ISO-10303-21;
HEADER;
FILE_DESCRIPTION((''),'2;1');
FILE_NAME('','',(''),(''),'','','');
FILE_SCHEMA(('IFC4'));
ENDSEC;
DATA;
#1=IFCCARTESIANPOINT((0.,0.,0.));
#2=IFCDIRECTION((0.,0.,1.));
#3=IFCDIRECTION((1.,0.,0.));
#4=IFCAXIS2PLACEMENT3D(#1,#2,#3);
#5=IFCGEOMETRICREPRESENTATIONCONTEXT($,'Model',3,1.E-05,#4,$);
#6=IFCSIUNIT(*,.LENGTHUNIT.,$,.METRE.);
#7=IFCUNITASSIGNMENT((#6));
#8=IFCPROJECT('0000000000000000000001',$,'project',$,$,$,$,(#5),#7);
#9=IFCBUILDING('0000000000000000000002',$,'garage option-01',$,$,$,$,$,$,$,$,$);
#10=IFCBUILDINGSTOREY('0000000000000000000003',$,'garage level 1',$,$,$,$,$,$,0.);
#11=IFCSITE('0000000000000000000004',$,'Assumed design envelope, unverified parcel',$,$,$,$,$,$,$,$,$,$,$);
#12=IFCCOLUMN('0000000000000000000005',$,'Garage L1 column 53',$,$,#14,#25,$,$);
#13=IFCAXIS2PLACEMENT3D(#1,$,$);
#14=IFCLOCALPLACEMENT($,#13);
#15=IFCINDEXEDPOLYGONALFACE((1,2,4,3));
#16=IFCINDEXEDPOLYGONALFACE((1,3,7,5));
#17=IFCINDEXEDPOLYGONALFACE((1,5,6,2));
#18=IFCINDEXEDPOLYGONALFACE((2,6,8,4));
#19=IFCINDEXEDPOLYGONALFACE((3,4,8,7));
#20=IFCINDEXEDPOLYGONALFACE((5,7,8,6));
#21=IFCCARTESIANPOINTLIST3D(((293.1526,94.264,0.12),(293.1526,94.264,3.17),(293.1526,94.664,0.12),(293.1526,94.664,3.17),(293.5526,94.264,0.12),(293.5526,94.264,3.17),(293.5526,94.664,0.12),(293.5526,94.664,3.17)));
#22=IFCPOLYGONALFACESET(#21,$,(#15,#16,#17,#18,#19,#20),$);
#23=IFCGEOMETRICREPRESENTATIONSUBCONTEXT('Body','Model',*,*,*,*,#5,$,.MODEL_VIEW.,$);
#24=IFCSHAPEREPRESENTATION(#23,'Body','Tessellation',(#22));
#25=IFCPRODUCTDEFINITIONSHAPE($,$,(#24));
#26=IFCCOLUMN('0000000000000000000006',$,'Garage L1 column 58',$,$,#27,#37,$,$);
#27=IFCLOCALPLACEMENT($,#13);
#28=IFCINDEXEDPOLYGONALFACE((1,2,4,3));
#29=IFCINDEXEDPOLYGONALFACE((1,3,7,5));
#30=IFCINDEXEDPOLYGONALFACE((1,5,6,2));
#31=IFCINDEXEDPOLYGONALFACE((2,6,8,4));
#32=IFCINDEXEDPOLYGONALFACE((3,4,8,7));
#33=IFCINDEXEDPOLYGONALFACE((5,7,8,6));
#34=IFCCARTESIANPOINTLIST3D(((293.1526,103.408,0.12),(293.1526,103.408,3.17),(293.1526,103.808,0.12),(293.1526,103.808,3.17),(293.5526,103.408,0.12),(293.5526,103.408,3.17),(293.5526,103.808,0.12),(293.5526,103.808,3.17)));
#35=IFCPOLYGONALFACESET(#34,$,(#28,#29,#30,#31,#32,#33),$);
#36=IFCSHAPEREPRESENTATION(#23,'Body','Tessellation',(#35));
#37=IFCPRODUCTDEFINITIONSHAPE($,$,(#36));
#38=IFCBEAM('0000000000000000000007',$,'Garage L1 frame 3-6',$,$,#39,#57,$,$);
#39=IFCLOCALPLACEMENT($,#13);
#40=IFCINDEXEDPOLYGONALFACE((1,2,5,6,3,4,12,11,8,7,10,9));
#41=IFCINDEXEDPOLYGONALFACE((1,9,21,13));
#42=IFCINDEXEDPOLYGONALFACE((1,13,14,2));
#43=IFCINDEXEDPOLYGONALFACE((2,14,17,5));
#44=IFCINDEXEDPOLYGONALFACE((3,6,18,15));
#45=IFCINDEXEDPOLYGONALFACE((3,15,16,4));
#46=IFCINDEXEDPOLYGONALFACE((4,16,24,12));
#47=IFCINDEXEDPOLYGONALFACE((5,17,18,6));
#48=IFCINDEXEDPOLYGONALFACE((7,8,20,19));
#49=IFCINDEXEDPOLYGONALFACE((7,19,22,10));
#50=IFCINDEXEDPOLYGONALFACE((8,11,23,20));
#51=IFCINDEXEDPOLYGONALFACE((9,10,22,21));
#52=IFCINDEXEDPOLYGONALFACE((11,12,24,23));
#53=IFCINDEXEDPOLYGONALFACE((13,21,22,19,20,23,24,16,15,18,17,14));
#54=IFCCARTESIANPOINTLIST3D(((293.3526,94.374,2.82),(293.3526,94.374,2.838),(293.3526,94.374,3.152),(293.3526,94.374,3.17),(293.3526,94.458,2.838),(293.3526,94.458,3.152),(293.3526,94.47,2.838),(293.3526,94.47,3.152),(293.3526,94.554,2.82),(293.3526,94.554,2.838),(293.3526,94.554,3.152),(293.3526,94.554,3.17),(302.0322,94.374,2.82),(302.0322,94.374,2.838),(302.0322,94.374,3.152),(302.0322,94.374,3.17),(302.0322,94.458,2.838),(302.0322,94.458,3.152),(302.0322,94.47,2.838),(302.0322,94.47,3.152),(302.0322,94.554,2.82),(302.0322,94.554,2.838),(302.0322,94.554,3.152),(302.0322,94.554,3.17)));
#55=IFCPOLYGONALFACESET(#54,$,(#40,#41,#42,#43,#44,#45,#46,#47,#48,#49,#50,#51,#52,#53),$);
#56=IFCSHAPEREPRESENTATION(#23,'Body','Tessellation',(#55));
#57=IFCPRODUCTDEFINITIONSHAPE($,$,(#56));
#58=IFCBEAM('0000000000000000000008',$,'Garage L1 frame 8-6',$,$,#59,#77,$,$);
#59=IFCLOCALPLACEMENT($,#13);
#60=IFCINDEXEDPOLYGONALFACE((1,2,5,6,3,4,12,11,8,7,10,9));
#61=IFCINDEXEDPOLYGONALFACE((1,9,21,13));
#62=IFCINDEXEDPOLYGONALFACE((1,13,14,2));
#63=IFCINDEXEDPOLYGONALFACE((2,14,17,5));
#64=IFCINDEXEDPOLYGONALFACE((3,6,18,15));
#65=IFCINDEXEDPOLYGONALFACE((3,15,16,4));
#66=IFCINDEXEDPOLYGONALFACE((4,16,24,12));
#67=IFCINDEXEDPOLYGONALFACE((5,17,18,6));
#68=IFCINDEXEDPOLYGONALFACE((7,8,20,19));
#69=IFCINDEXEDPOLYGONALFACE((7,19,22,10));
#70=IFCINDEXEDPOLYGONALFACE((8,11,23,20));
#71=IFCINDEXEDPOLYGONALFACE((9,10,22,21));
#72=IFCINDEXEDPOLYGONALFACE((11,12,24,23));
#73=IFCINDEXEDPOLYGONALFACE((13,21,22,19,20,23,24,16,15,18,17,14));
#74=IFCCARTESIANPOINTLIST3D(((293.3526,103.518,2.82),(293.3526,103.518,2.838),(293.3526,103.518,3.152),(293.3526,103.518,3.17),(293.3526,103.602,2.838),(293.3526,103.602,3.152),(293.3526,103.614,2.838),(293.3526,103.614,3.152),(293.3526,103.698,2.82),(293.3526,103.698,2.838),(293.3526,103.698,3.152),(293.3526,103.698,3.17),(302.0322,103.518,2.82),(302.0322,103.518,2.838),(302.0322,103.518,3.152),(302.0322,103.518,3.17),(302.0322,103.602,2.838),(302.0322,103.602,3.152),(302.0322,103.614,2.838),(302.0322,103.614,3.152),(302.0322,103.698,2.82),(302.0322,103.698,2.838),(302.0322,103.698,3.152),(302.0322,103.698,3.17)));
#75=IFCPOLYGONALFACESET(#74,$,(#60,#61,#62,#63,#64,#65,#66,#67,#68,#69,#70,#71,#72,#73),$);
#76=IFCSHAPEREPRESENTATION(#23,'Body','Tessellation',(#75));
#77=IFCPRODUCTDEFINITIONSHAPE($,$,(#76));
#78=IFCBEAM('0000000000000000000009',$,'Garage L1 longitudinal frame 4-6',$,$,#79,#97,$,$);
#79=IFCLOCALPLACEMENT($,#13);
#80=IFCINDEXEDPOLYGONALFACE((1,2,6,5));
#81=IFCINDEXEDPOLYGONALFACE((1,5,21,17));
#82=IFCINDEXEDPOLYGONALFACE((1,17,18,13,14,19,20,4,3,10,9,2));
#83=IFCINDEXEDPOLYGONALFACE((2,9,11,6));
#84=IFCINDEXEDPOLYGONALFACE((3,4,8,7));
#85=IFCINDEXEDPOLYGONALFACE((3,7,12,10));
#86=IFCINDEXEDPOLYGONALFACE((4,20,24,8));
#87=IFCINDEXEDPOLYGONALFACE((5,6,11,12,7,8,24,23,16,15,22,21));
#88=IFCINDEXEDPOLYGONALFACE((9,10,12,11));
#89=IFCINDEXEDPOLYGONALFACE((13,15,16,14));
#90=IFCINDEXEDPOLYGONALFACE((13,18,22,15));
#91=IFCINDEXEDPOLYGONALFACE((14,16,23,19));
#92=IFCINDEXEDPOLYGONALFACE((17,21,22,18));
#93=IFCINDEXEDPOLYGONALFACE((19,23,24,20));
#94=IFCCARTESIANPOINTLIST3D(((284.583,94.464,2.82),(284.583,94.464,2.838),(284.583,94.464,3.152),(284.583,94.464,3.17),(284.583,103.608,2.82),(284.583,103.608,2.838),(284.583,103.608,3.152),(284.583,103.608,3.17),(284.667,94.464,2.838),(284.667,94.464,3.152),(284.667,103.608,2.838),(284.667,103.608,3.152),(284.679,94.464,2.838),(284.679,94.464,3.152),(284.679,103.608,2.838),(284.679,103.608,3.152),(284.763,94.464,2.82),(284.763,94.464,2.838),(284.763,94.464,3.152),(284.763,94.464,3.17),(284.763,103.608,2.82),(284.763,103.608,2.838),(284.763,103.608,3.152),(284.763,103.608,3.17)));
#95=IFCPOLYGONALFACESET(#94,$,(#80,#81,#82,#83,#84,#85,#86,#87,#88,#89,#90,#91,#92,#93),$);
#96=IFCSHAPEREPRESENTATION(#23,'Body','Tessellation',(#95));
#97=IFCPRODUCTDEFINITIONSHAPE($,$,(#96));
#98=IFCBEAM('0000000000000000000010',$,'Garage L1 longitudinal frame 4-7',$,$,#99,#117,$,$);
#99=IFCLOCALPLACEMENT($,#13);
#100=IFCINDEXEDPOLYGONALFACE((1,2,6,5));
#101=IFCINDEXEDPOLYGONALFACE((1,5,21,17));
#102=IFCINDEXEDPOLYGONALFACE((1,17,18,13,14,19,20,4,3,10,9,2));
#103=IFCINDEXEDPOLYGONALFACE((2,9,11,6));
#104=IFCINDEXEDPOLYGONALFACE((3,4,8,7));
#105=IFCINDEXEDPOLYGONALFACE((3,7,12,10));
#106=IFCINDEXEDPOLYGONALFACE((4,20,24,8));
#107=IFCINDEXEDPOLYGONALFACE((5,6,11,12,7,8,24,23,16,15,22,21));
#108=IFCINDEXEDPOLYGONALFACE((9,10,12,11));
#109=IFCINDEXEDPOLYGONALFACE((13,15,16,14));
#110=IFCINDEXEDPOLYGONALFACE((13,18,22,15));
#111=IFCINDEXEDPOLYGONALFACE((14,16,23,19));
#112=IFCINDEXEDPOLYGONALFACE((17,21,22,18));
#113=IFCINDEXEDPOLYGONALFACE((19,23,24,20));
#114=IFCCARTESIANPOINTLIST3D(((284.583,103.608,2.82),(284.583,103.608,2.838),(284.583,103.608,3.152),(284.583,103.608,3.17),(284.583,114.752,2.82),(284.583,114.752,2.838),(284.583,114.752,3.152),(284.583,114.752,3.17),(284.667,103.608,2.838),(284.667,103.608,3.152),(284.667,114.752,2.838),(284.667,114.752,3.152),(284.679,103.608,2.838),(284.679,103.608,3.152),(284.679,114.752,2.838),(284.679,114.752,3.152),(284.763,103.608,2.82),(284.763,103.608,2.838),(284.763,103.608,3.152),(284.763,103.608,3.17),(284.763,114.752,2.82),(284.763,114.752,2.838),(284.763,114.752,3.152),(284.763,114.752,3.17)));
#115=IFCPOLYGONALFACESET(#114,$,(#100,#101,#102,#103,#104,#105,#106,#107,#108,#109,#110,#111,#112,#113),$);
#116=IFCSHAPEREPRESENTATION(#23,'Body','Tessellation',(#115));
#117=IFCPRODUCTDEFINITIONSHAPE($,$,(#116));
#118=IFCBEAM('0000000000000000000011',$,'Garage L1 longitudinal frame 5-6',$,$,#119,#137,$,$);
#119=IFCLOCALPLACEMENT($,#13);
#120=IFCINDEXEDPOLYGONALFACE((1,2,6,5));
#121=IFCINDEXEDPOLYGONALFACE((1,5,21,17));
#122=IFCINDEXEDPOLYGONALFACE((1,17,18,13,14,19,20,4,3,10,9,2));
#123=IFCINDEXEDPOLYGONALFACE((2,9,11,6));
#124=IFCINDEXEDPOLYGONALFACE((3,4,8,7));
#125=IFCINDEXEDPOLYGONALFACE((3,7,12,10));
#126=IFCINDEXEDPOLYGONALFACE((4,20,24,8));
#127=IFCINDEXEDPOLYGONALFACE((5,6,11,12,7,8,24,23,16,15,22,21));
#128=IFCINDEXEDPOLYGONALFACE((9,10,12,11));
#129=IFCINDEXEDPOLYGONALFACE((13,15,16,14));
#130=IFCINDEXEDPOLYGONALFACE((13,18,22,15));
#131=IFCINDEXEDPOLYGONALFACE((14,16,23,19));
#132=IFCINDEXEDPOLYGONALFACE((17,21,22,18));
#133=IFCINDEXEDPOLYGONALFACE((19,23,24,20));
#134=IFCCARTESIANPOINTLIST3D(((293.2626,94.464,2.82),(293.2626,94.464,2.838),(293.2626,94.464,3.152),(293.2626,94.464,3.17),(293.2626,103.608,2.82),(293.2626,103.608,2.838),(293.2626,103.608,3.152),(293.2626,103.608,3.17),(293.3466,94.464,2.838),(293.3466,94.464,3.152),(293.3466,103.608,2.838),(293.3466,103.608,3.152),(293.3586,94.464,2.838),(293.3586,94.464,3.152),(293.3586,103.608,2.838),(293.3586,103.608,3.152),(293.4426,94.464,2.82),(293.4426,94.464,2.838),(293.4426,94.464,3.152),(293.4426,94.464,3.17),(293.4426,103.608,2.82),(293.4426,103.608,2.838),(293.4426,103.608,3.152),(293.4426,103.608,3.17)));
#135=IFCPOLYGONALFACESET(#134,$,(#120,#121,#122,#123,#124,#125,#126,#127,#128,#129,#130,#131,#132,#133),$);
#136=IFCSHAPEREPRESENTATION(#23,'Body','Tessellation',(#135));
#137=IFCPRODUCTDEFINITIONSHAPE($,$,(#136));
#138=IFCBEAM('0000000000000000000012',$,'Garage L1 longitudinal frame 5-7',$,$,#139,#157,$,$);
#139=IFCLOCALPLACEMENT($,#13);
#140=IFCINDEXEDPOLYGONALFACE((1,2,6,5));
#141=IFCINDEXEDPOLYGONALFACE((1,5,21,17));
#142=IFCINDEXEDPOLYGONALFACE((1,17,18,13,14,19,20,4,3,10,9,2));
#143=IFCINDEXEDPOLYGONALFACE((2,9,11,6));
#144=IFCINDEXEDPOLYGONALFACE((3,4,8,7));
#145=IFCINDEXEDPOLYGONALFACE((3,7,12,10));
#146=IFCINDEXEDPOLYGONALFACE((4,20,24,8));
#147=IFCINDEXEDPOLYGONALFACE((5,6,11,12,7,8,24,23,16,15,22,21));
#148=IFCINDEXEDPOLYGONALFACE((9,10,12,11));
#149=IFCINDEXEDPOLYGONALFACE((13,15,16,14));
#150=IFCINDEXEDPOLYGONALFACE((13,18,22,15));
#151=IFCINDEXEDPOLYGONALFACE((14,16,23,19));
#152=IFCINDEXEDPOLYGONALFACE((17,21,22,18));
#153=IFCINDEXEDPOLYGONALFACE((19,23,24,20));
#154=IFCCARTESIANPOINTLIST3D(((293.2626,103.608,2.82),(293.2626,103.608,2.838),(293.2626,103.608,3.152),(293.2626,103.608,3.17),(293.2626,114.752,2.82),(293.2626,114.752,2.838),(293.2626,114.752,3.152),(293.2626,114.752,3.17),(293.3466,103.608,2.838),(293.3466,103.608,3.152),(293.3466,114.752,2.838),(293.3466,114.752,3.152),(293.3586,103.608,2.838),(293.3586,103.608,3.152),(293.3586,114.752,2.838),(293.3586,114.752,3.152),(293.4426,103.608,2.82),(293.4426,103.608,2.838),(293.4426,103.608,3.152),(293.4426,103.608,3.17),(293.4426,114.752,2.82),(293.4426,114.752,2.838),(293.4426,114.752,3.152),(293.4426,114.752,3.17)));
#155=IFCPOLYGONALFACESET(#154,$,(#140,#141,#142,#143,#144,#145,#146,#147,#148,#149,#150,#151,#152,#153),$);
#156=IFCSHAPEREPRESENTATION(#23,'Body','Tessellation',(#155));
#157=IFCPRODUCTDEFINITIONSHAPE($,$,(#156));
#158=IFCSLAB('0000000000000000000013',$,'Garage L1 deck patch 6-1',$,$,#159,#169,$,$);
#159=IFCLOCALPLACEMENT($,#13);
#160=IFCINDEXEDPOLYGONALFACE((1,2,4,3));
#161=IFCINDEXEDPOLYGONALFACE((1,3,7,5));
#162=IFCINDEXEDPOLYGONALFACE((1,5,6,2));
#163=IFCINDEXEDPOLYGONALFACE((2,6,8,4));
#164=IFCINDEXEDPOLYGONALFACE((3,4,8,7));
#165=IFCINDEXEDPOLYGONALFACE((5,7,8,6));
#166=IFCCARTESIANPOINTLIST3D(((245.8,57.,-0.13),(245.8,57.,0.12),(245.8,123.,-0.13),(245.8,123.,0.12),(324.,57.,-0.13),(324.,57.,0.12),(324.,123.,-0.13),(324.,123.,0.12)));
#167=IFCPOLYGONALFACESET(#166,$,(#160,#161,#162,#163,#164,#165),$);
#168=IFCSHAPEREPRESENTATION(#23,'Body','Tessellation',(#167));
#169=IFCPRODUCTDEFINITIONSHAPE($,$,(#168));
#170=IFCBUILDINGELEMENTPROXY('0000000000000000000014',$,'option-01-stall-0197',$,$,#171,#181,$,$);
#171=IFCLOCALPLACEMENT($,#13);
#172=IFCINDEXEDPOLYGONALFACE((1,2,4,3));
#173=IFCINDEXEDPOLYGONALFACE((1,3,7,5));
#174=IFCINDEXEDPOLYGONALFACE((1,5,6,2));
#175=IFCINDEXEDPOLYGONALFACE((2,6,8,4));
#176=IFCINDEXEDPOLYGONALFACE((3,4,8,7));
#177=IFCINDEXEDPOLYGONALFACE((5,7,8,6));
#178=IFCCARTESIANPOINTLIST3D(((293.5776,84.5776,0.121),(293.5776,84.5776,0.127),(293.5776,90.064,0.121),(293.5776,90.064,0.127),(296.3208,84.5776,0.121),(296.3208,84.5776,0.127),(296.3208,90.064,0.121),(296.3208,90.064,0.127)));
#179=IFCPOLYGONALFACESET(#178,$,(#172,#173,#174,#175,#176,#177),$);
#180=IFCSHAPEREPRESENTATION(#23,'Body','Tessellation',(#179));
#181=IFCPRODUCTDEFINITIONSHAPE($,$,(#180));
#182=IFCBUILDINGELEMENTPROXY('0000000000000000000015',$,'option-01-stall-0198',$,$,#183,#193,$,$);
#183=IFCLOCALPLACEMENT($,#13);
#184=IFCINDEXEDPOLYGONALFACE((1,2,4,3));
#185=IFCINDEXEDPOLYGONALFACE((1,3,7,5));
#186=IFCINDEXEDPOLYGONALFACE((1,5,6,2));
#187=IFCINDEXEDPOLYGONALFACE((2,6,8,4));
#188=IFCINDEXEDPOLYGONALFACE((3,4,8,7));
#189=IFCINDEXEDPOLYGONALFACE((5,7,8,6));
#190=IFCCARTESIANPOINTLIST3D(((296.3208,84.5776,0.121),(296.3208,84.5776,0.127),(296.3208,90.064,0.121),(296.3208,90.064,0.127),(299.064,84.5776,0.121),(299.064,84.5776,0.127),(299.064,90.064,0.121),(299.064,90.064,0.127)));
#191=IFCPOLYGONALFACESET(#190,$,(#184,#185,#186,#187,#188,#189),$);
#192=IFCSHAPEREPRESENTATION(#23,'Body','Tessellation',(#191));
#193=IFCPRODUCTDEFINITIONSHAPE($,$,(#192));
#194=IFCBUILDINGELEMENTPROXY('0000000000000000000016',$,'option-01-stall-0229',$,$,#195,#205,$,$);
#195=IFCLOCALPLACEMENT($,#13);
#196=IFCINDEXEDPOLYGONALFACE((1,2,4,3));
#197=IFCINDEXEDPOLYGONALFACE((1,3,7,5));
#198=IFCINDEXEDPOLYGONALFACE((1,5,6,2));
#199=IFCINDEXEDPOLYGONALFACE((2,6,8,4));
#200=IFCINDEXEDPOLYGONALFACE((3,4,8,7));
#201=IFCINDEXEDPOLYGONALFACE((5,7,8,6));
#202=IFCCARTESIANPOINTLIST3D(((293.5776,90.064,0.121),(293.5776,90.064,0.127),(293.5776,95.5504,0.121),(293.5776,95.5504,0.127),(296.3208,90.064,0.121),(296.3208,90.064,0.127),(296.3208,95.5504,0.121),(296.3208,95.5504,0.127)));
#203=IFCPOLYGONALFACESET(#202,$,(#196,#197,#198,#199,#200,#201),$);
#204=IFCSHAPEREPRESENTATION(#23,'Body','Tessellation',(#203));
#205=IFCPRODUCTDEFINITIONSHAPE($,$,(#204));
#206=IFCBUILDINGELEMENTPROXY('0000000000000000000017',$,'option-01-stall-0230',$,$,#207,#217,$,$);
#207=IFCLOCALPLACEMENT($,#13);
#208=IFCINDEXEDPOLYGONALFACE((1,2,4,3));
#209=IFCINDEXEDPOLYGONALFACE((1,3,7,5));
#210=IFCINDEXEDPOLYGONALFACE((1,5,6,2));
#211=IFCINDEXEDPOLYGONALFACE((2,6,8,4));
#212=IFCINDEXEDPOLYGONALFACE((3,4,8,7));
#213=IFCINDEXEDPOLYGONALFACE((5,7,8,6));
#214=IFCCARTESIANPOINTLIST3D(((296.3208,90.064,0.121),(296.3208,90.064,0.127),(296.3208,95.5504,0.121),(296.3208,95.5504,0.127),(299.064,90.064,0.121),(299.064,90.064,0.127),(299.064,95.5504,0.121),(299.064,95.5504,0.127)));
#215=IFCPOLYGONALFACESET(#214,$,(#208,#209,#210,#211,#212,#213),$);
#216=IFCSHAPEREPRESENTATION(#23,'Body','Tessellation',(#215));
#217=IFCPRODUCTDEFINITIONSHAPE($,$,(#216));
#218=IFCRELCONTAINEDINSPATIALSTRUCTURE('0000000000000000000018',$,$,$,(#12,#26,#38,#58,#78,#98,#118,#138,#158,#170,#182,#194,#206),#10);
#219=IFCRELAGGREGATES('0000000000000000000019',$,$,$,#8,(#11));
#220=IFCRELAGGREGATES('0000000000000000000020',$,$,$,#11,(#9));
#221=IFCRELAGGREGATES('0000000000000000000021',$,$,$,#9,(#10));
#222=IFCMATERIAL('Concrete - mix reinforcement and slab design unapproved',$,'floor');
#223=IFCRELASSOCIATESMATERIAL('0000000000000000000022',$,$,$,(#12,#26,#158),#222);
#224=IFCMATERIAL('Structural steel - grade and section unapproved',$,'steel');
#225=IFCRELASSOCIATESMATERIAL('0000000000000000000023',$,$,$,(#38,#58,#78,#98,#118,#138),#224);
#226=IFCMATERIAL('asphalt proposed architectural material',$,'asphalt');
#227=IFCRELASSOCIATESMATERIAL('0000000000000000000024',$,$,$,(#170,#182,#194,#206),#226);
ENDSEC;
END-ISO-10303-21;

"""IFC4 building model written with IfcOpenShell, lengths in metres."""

from ifc_helpers import new_model, si_unit, frame, origin_with_axes, place, context, subcontext, project, spatial, rectangle, i_section, extrude, material, element, save


model = new_model("IFC4")

# Units and contexts
model_context = context("Model", 3, precision=1e-05, world=origin_with_axes())
body_context = subcontext(model_context, "Body", "Model", "MODEL_VIEW")
ifc_project = project(units=[si_unit("LENGTHUNIT", "METRE")], contexts=[model_context])

# Site, building, storey
site = spatial("IfcSite", under=ifc_project, Name="Assumed design envelope, unverified parcel")
building = spatial("IfcBuilding", under=site, Name="garage option-01")
storey = spatial("IfcBuildingStorey", under=building, Name="garage level 1", Elevation=0.0)

# Columns
ifc_material_1 = material(Name="Concrete - mix reinforcement and slab design unapproved", Category="floor")
for number, where, z_axis, x_axis, name in (
    (1, (293.3526, 94.464, 0.12), (0.0, 0.0, 1.0), (1.0, 0.0, 0.0), "Garage L1 column 53"),
    (2, (293.3526, 103.608, 0.12), (0.0, 0.0, 1.0), (1.0, 0.0, 0.0), "Garage L1 column 58"),
):
    element("IfcColumn", number, at=place(None, frame(where, z_axis=z_axis, x_axis=x_axis)), inside=storey, material=ifc_material_1, Name=name, context=body_context, shape_type="SweptSolid", body=[
        extrude(rectangle(XDim=0.4, YDim=0.4), origin_with_axes(), (0.0, 0.0, 1.0), 3.05),
    ])

# Beams
ifc_material_2 = material(Name="Structural steel - grade and section unapproved", Category="steel")
for number, where, z_axis, x_axis, name in (
    (3, (293.3526, 94.464, 2.995), (1.0, 0.0, 0.0), (0.0, 1.0, 0.0), "Garage L1 frame 3-6"),
    (4, (293.3526, 103.608, 2.995), (1.0, 0.0, 0.0), (0.0, 1.0, 0.0), "Garage L1 frame 8-6"),
):
    element("IfcBeam", number, at=place(None, frame(where, z_axis=z_axis, x_axis=x_axis)), inside=storey, material=ifc_material_2, Name=name, context=body_context, shape_type="SweptSolid", body=[
        extrude(i_section(OverallWidth=0.18, OverallDepth=0.35, WebThickness=0.012, FlangeThickness=0.018, FilletRadius=0.0), origin_with_axes(), (0.0, 0.0, 1.0), 8.6796),
    ])
beam_1_placement = place(None, frame((284.673, 94.464, 2.995), z_axis=(0.0, 1.0, 0.0), x_axis=(-1.0, 0.0, 0.0)))
element("IfcBeam", 5, at=beam_1_placement, inside=storey, material=ifc_material_2, Name="Garage L1 longitudinal frame 4-6", context=body_context, shape_type="SweptSolid", body=[
    extrude(i_section(OverallWidth=0.18, OverallDepth=0.35, WebThickness=0.012, FlangeThickness=0.018, FilletRadius=0.0), origin_with_axes(), (0.0, 0.0, 1.0), 9.144),
])
beam_2_placement = place(None, frame((284.673, 103.608, 2.995), z_axis=(0.0, 1.0, 0.0), x_axis=(-1.0, 0.0, 0.0)))
element("IfcBeam", 6, at=beam_2_placement, inside=storey, material=ifc_material_2, Name="Garage L1 longitudinal frame 4-7", context=body_context, shape_type="SweptSolid", body=[
    extrude(i_section(OverallWidth=0.18, OverallDepth=0.35, WebThickness=0.012, FlangeThickness=0.018, FilletRadius=0.0), origin_with_axes(), (0.0, 0.0, 1.0), 11.144),
])
beam_3_placement = place(None, frame((293.3526, 94.464, 2.995), z_axis=(0.0, 1.0, 0.0), x_axis=(-1.0, 0.0, 0.0)))
element("IfcBeam", 7, at=beam_3_placement, inside=storey, material=ifc_material_2, Name="Garage L1 longitudinal frame 5-6", context=body_context, shape_type="SweptSolid", body=[
    extrude(i_section(OverallWidth=0.18, OverallDepth=0.35, WebThickness=0.012, FlangeThickness=0.018, FilletRadius=0.0), origin_with_axes(), (0.0, 0.0, 1.0), 9.144),
])
beam_4_placement = place(None, frame((293.3526, 103.608, 2.995), z_axis=(0.0, 1.0, 0.0), x_axis=(-1.0, 0.0, 0.0)))
element("IfcBeam", 8, at=beam_4_placement, inside=storey, material=ifc_material_2, Name="Garage L1 longitudinal frame 5-7", context=body_context, shape_type="SweptSolid", body=[
    extrude(i_section(OverallWidth=0.18, OverallDepth=0.35, WebThickness=0.012, FlangeThickness=0.018, FilletRadius=0.0), origin_with_axes(), (0.0, 0.0, 1.0), 11.144),
])

# Slab
slab_placement = place(None, frame((284.9, 90.0, -0.13), z_axis=(0.0, 0.0, 1.0), x_axis=(1.0, 0.0, 0.0)))
element("IfcSlab", 9, at=slab_placement, inside=storey, material=ifc_material_1, Name="Garage L1 deck patch 6-1", context=body_context, shape_type="SweptSolid", body=[
    extrude(rectangle(XDim=78.2, YDim=66.0), origin_with_axes(), (0.0, 0.0, 1.0), 0.25),
])

# Building element proxies
ifc_material_3 = material(Name="asphalt proposed architectural material", Category="asphalt")
for number, where, z_axis, x_axis, name in (
    (10, (294.9492, 87.3208, 0.121), (0.0, 0.0, 1.0), (1.0, 0.0, 0.0), "option-01-stall-0197"),
    (11, (297.6924, 87.3208, 0.121), (0.0, 0.0, 1.0), (1.0, 0.0, 0.0), "option-01-stall-0198"),
    (12, (294.9492, 92.8072, 0.121), (0.0, 0.0, 1.0), (1.0, 0.0, 0.0), "option-01-stall-0229"),
    (13, (297.6924, 92.8072, 0.121), (0.0, 0.0, 1.0), (1.0, 0.0, 0.0), "option-01-stall-0230"),
):
    element("IfcBuildingElementProxy", number, at=place(None, frame(where, z_axis=z_axis, x_axis=x_axis)), inside=storey, material=ifc_material_3, Name=name, context=body_context, shape_type="SweptSolid", body=[
        extrude(rectangle(XDim=2.7432, YDim=5.4864), origin_with_axes(), (0.0, 0.0, 1.0), 0.006),
    ])

save(model, "model.ifc")
